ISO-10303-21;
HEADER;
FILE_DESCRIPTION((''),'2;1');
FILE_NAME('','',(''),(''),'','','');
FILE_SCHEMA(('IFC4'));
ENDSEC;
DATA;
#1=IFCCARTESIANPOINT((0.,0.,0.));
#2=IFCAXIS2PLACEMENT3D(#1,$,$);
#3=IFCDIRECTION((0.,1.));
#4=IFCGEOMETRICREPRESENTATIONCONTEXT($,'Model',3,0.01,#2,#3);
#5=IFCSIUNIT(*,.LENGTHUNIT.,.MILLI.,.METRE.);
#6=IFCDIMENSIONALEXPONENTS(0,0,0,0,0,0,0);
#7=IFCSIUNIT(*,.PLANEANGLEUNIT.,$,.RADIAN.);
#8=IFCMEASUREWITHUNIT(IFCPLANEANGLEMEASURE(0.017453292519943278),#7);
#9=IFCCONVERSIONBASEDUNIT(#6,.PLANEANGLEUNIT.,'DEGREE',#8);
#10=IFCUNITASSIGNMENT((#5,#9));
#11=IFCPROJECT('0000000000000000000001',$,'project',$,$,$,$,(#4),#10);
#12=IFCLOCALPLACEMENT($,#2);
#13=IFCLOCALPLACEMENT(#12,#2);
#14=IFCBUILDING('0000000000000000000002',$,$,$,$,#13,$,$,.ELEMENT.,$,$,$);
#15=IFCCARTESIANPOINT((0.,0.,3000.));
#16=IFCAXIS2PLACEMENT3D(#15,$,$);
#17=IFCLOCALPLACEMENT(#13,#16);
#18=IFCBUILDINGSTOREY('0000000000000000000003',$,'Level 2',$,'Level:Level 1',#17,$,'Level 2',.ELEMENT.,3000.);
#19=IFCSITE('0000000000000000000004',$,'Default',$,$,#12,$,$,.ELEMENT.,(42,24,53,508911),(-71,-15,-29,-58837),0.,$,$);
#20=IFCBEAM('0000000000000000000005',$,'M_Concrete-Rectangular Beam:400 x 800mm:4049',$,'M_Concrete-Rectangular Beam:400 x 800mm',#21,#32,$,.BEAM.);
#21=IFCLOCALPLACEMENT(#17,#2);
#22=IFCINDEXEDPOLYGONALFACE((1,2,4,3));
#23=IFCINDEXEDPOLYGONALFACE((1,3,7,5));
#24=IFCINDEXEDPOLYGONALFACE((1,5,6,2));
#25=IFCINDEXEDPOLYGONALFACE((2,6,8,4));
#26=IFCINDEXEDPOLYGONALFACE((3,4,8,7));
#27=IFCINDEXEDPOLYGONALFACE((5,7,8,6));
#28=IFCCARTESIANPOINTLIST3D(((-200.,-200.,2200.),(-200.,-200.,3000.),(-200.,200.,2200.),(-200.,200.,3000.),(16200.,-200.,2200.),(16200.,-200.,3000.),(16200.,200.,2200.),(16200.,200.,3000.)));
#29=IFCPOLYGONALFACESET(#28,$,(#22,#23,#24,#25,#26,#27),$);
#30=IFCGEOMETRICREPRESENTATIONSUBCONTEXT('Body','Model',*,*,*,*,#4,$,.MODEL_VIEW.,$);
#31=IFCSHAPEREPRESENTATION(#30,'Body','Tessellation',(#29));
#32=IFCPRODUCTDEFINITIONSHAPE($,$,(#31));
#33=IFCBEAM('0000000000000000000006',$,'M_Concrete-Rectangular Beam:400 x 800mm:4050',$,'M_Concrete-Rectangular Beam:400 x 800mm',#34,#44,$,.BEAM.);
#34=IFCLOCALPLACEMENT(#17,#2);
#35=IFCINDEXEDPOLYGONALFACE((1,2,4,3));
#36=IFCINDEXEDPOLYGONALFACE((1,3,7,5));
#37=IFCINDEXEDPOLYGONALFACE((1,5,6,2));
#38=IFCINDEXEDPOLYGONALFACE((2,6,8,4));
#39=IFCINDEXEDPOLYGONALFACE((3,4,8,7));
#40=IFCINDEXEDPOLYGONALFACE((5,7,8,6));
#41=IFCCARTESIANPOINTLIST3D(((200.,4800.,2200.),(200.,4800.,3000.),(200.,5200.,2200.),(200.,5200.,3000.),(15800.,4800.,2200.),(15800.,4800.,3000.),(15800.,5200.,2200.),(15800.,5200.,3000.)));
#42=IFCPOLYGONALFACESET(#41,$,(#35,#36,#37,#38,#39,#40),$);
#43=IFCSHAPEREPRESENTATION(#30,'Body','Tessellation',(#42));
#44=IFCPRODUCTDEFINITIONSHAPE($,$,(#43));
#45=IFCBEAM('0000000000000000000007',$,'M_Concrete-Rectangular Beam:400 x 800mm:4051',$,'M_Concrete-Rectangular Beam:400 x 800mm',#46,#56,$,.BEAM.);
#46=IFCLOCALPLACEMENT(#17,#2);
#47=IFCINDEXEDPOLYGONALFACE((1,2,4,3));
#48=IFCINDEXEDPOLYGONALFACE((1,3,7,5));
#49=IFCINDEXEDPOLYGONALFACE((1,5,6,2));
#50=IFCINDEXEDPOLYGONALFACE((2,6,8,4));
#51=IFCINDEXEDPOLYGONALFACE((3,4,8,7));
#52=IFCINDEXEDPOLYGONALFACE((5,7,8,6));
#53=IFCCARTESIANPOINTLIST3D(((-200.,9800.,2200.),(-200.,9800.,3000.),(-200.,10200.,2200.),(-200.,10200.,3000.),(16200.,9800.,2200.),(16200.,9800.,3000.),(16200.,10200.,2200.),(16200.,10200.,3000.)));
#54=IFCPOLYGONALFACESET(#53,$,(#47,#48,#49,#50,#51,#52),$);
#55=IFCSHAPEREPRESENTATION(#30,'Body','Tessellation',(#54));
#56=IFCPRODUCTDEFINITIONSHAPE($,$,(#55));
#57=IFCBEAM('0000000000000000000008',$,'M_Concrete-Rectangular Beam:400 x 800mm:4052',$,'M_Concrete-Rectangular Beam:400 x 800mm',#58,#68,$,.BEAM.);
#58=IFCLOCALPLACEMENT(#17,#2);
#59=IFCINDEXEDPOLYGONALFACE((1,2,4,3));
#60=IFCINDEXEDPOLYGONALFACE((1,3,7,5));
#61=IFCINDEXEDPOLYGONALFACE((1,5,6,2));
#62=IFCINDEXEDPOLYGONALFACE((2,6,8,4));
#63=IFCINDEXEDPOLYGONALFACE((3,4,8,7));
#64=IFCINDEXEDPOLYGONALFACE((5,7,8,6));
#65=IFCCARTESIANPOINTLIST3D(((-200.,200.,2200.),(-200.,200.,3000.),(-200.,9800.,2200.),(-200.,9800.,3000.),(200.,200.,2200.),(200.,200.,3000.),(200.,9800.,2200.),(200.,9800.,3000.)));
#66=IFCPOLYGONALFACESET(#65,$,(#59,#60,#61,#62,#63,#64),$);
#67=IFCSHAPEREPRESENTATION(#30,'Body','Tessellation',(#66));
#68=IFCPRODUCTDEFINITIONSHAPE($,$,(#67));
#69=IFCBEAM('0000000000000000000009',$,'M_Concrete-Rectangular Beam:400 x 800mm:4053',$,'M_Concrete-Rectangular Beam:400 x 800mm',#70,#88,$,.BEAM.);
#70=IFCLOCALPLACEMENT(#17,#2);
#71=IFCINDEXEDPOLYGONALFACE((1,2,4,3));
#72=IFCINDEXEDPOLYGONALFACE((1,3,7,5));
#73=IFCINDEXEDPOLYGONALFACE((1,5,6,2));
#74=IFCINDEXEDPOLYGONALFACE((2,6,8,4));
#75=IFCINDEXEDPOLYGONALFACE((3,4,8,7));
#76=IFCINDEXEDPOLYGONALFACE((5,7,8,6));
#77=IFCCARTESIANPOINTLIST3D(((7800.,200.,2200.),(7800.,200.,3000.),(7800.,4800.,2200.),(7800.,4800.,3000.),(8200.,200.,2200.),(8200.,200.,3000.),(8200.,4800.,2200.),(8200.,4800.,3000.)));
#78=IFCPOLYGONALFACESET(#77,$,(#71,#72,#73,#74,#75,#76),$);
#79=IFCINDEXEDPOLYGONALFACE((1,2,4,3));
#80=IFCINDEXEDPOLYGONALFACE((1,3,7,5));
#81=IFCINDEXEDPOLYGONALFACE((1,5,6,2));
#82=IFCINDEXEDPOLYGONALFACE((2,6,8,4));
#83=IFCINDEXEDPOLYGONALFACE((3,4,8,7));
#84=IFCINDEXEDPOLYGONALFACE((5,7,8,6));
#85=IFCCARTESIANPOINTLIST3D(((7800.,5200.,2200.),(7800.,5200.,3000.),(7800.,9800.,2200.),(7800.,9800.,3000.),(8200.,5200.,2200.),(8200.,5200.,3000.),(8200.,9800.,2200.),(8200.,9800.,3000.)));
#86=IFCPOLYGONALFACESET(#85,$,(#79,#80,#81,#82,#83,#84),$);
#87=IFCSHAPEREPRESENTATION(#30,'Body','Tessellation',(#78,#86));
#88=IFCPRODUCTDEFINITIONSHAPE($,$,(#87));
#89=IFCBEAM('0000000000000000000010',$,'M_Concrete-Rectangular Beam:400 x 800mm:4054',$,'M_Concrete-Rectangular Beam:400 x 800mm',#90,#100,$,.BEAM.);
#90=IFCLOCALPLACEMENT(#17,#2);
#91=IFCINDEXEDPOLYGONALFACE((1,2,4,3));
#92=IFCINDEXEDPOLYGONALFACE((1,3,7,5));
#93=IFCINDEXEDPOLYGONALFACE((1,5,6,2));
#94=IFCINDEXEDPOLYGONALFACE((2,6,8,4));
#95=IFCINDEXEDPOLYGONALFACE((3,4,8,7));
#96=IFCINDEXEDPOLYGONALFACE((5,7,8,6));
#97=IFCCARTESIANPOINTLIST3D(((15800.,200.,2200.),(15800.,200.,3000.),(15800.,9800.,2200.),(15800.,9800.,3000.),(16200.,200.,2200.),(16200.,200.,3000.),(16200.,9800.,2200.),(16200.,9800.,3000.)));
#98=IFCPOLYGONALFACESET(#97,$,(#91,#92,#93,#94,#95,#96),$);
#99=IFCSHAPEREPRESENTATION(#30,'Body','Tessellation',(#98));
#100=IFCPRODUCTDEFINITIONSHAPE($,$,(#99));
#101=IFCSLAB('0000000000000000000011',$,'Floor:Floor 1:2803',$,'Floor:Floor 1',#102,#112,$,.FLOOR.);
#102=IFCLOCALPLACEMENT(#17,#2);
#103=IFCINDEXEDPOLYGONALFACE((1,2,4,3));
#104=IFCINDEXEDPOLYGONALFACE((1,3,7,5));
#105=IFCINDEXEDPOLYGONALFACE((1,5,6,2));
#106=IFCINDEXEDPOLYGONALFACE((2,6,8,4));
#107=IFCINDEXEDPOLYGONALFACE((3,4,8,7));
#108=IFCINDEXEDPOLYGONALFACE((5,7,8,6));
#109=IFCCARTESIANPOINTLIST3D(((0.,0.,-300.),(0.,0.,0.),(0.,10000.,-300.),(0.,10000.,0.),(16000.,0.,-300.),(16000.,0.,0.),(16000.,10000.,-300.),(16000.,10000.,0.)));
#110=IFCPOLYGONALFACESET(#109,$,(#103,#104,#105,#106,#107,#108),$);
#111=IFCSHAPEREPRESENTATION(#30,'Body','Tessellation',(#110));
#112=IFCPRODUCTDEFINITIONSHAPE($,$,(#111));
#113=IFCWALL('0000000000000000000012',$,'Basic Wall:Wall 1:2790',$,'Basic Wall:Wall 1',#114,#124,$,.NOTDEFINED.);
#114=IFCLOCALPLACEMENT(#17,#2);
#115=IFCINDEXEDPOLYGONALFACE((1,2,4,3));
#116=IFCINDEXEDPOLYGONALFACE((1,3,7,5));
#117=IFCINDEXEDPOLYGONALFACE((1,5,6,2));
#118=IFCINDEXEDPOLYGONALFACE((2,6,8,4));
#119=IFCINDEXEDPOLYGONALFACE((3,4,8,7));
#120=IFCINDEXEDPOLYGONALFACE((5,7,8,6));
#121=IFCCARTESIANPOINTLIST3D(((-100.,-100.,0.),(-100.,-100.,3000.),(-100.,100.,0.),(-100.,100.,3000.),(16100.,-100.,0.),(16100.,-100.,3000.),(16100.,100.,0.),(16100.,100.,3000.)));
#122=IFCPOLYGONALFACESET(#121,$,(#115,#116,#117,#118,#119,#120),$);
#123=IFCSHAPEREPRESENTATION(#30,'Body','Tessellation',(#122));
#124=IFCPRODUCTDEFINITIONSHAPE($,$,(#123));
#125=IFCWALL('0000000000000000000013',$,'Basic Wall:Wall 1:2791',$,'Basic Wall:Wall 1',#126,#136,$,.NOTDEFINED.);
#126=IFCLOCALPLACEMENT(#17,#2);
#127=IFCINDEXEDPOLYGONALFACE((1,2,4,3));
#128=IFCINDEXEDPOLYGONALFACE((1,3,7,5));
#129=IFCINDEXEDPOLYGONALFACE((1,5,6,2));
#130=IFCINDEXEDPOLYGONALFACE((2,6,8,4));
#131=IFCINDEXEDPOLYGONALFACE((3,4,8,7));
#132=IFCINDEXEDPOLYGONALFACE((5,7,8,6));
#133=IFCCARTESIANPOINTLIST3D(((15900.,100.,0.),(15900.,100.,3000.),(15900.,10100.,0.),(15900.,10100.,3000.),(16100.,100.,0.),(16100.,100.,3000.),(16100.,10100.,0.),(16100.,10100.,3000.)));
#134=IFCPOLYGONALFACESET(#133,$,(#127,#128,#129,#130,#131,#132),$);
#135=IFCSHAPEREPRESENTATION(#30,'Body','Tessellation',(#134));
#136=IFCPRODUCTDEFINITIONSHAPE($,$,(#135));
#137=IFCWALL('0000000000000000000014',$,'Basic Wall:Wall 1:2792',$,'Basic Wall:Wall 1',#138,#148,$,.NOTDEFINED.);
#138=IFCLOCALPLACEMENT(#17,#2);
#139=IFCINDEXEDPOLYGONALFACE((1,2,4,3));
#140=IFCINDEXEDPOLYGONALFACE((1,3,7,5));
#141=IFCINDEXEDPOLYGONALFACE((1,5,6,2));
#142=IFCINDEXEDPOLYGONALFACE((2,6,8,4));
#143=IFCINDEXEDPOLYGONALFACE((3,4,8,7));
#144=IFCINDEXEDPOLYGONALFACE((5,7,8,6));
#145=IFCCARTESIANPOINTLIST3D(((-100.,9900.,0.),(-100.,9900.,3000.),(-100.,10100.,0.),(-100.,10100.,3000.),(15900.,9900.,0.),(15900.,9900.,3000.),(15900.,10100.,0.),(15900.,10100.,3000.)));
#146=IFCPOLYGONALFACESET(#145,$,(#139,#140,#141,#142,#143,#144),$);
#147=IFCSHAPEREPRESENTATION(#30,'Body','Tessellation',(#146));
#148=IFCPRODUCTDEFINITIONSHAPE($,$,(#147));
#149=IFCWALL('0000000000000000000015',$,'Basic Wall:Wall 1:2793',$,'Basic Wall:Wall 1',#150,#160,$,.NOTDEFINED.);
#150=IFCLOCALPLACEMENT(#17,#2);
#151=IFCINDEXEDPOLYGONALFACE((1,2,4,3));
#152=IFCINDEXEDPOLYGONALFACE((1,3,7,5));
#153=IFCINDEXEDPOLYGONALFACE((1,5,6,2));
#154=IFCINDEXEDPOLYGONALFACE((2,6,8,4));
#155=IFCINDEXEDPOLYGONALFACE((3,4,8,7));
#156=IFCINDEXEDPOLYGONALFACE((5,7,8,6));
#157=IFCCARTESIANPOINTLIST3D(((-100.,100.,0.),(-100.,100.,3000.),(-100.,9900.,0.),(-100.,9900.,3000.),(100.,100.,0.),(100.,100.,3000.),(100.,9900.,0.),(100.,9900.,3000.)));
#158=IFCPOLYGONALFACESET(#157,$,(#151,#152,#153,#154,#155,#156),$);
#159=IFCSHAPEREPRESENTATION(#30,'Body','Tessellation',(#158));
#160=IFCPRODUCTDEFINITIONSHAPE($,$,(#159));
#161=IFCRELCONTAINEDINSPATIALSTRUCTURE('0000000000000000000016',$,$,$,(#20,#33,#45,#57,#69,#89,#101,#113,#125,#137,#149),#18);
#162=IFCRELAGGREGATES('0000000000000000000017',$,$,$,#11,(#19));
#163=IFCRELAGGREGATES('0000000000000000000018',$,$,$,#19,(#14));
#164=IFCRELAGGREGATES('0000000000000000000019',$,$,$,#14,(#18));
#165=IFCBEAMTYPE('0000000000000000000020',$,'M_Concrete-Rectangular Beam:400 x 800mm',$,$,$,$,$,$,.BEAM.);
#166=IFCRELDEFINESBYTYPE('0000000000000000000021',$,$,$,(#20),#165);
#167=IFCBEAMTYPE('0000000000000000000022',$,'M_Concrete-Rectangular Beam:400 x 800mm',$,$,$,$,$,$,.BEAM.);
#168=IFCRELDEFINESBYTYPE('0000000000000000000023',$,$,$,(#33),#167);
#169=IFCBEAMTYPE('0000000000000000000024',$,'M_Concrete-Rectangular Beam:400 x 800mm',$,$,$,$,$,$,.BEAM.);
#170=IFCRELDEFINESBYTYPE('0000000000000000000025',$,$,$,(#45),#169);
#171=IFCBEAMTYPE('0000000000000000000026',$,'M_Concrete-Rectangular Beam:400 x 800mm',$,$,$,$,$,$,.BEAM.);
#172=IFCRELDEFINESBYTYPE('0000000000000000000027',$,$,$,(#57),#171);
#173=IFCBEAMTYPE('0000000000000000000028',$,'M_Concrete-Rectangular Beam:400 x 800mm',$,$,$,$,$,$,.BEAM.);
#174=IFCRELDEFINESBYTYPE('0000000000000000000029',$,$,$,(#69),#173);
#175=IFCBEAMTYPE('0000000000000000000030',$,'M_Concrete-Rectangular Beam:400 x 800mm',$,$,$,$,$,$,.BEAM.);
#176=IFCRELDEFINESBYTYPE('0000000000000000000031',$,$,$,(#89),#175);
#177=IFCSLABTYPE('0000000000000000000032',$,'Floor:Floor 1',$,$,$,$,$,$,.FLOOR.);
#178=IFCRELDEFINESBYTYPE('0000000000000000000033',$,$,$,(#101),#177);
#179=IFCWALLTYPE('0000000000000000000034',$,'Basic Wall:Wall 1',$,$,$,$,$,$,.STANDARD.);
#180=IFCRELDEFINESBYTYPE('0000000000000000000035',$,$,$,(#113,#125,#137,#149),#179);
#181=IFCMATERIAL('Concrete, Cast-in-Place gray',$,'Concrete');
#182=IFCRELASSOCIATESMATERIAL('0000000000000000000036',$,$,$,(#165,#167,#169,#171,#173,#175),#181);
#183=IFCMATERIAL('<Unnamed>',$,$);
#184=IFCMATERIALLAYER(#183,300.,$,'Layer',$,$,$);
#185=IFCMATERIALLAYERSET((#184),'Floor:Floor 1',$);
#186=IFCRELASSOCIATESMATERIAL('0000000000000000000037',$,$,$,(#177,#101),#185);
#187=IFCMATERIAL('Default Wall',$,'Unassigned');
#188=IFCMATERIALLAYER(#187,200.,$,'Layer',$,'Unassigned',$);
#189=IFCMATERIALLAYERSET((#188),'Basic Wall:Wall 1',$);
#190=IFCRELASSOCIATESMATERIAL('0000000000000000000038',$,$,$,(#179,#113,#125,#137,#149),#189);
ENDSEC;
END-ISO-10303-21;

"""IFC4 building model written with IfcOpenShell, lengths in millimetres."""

from ifc_helpers import new_model, entity, si_unit, converted_unit, direction, frame, frame_2d, origin, origin_2d_with_axis, place, context, subcontext, project, spatial, rectangle, extrude, source, transform, mapped, material, layer, layer_set, layer_usage, material_profile, profile_set, type_object, type_shapes, element, save


model = new_model("IFC4")

# Units and contexts
model_context = context("Model", 3, precision=0.01, world=origin(), true_north=direction((0.0, 1.0)))
body_context = subcontext(model_context, "Body", "Model", "MODEL_VIEW")
ifc_project = project(units=[si_unit("LENGTHUNIT", "METRE", prefix="MILLI"), converted_unit("PLANEANGLEUNIT", "DEGREE", entity("IfcPlaneAngleMeasure", 0.017453292519943278), si_unit("PLANEANGLEUNIT", "RADIAN"), dimensions=[0, 0, 0, 0, 0, 0, 0])], contexts=[model_context])

# Site, building, storey
site_placement = place(None, origin())
site = spatial("IfcSite", under=ifc_project, at=site_placement, Name="Default", CompositionType="ELEMENT", RefLatitude=(42, 24, 53, 508911), RefLongitude=(-71, -15, -29, -58837), RefElevation=0.0)
building_placement = place(site_placement, origin())
building = spatial("IfcBuilding", under=site, at=building_placement, CompositionType="ELEMENT")
storey_placement = place(building_placement, frame((0.0, 0.0, 3000.0)))
storey = spatial("IfcBuildingStorey", under=building, at=storey_placement, Name="Level 2", ObjectType="Level:Level 1", LongName="Level 2", CompositionType="ELEMENT", Elevation=3000.0)

# Beams
ifc_material_1 = material(Name="Concrete, Cast-in-Place gray", Category="Concrete")
ifc_material_profile = material_profile(ifc_material_1, rectangle(XDim=800.0, YDim=400.0, at=origin_2d_with_axis()), Name="400 x 800mm")
ifc_profile_set = profile_set([ifc_material_profile], Name="400 x 800mm")
beam_type_1 = type_object("IfcBeamType", Name="M_Concrete-Rectangular Beam:400 x 800mm", PredefinedType="BEAM", material=ifc_profile_set)
shared_shape_1 = source(origin(), body_context, "Body", "SweptSolid", [
    extrude(rectangle(XDim=800.0, YDim=400.0, at=origin_2d_with_axis()), frame((-200.0, 0.0, 5600.0), z_axis=(1.0, 0.0, 0.0), x_axis=(0.0, 0.0, -1.0)), (0.0, 0.0, 1.0), 16400.0),
])
type_shapes(beam_type_1, [shared_shape_1])
beam_1_placement = place(storey_placement, frame((0.0, 0.0, -3000.0)))
element("IfcBeam", 1, at=beam_1_placement, inside=storey, type_object=beam_type_1, Name="M_Concrete-Rectangular Beam:400 x 800mm:4049", ObjectType="M_Concrete-Rectangular Beam:400 x 800mm", PredefinedType="BEAM", context=body_context, shape_type="MappedRepresentation", body=[
    mapped(shared_shape_1, transform((0.0, 0.0, 0.0), scale=1.0)),
])
beam_type_2 = type_object("IfcBeamType", Name="M_Concrete-Rectangular Beam:400 x 800mm", PredefinedType="BEAM", material=ifc_profile_set)
shared_shape_2 = source(origin(), body_context, "Body", "SweptSolid", [
    extrude(rectangle(XDim=800.0, YDim=400.0, at=frame_2d((0.0, 0.0), x_axis=(1.0, 0.0))), frame((200.0, 5000.0, 5600.0), z_axis=(1.0, 0.0, 0.0), x_axis=(0.0, 0.0, -1.0)), (0.0, 0.0, 1.0), 15600.0),
])
type_shapes(beam_type_2, [shared_shape_2])
beam_2_placement = place(storey_placement, frame((0.0, 0.0, -3000.0)))
element("IfcBeam", 2, at=beam_2_placement, inside=storey, type_object=beam_type_2, Name="M_Concrete-Rectangular Beam:400 x 800mm:4050", ObjectType="M_Concrete-Rectangular Beam:400 x 800mm", PredefinedType="BEAM", context=body_context, shape_type="MappedRepresentation", body=[
    mapped(shared_shape_2, transform((0.0, 0.0, 0.0), scale=1.0)),
])
beam_type_3 = type_object("IfcBeamType", Name="M_Concrete-Rectangular Beam:400 x 800mm", PredefinedType="BEAM", material=ifc_profile_set)
shared_shape_3 = source(origin(), body_context, "Body", "SweptSolid", [
    extrude(rectangle(XDim=800.0, YDim=400.0, at=frame_2d((0.0, 0.0), x_axis=(1.0, 0.0))), frame((-200.0, 10000.0, 5600.0), z_axis=(1.0, 0.0, 0.0), x_axis=(0.0, 0.0, -1.0)), (0.0, 0.0, 1.0), 16400.0),
])
type_shapes(beam_type_3, [shared_shape_3])
beam_3_placement = place(storey_placement, frame((0.0, 0.0, -3000.0)))
element("IfcBeam", 3, at=beam_3_placement, inside=storey, type_object=beam_type_3, Name="M_Concrete-Rectangular Beam:400 x 800mm:4051", ObjectType="M_Concrete-Rectangular Beam:400 x 800mm", PredefinedType="BEAM", context=body_context, shape_type="MappedRepresentation", body=[
    mapped(shared_shape_3, transform((0.0, 0.0, 0.0), scale=1.0)),
])
beam_type_4 = type_object("IfcBeamType", Name="M_Concrete-Rectangular Beam:400 x 800mm", PredefinedType="BEAM", material=ifc_profile_set)
shared_shape_4 = source(origin(), body_context, "Body", "SweptSolid", [
    extrude(rectangle(XDim=800.0, YDim=400.0, at=frame_2d((0.0, 0.0), x_axis=(0.0, 1.0))), frame((0.0, 200.0, 5600.0), z_axis=(0.0, 1.0, 0.0), x_axis=(-1.0, 0.0, 0.0)), (0.0, 0.0, 1.0), 9600.0),
])
type_shapes(beam_type_4, [shared_shape_4])
beam_4_placement = place(storey_placement, frame((0.0, 0.0, -3000.0)))
element("IfcBeam", 4, at=beam_4_placement, inside=storey, type_object=beam_type_4, Name="M_Concrete-Rectangular Beam:400 x 800mm:4052", ObjectType="M_Concrete-Rectangular Beam:400 x 800mm", PredefinedType="BEAM", context=body_context, shape_type="MappedRepresentation", body=[
    mapped(shared_shape_4, transform((0.0, 0.0, 0.0), scale=1.0)),
])
beam_type_5 = type_object("IfcBeamType", Name="M_Concrete-Rectangular Beam:400 x 800mm", PredefinedType="BEAM", material=ifc_profile_set)
shared_shape_5 = source(origin(), body_context, "Body", "SweptSolid", [
    extrude(rectangle(XDim=800.0, YDim=400.0, at=frame_2d((0.0, 0.0), x_axis=(0.0, 1.0))), frame((8000.0, 200.0, 5600.0), z_axis=(0.0, 1.0, 0.0), x_axis=(-1.0, 0.0, 0.0)), (0.0, 0.0, 1.0), 4600.0),
    extrude(rectangle(XDim=800.0, YDim=400.0, at=frame_2d((0.0, 0.0), x_axis=(0.0, 1.0))), frame((8000.0, 5200.0, 5600.0), z_axis=(0.0, 1.0, 0.0), x_axis=(-1.0, 0.0, 0.0)), (0.0, 0.0, 1.0), 4600.0),
])
type_shapes(beam_type_5, [shared_shape_5])
beam_5_placement = place(storey_placement, frame((0.0, 0.0, -3000.0)))
element("IfcBeam", 5, at=beam_5_placement, inside=storey, type_object=beam_type_5, Name="M_Concrete-Rectangular Beam:400 x 800mm:4053", ObjectType="M_Concrete-Rectangular Beam:400 x 800mm", PredefinedType="BEAM", context=body_context, shape_type="MappedRepresentation", body=[
    mapped(shared_shape_5, transform((0.0, 0.0, 0.0), scale=1.0)),
])
beam_type_6 = type_object("IfcBeamType", Name="M_Concrete-Rectangular Beam:400 x 800mm", PredefinedType="BEAM", material=ifc_profile_set)
shared_shape_6 = source(origin(), body_context, "Body", "SweptSolid", [
    extrude(rectangle(XDim=800.0, YDim=400.0, at=frame_2d((0.0, 0.0), x_axis=(0.0, 1.0))), frame((16000.0, 200.0, 5600.0), z_axis=(0.0, 1.0, 0.0), x_axis=(-1.0, 0.0, 0.0)), (0.0, 0.0, 1.0), 9600.0),
])
type_shapes(beam_type_6, [shared_shape_6])
beam_6_placement = place(storey_placement, frame((0.0, 0.0, -3000.0)))
element("IfcBeam", 6, at=beam_6_placement, inside=storey, type_object=beam_type_6, Name="M_Concrete-Rectangular Beam:400 x 800mm:4054", ObjectType="M_Concrete-Rectangular Beam:400 x 800mm", PredefinedType="BEAM", context=body_context, shape_type="MappedRepresentation", body=[
    mapped(shared_shape_6, transform((0.0, 0.0, 0.0), scale=1.0)),
])

# Slab
ifc_material_2 = material(Name="<Unnamed>")
ifc_layer_1 = layer(ifc_material_2, 300.0, Name="Layer")
ifc_layer_set_1 = layer_set([ifc_layer_1], Name="Floor:Floor 1")
ifc_layer_usage_1 = layer_usage(ifc_layer_set_1, "AXIS3", "POSITIVE", 0.0)
slab_type = type_object("IfcSlabType", Name="Floor:Floor 1", PredefinedType="FLOOR", material=ifc_layer_set_1)
slab_placement = place(storey_placement, origin())
element("IfcSlab", 7, at=slab_placement, inside=storey, type_object=slab_type, material=ifc_layer_usage_1, Name="Floor:Floor 1:2803", ObjectType="Floor:Floor 1", PredefinedType="FLOOR", context=body_context, shape_type="SweptSolid", body=[
    extrude(rectangle(XDim=10000.0, YDim=16000.0, at=origin_2d_with_axis()), frame((8000.0, 5000.0, 0.0), z_axis=(0.0, 0.0, -1.0), x_axis=(0.0, 1.0, 0.0)), (0.0, 0.0, 1.0), 300.0),
])

# Walls
ifc_material_3 = material(Name="Default Wall", Category="Unassigned")
ifc_layer_2 = layer(ifc_material_3, 200.0, Name="Layer", Category="Unassigned")
ifc_layer_set_2 = layer_set([ifc_layer_2], Name="Basic Wall:Wall 1")
ifc_layer_usage_2 = layer_usage(ifc_layer_set_2, "AXIS2", "NEGATIVE", 100.0)
wall_type = type_object("IfcWallType", Name="Basic Wall:Wall 1", PredefinedType="STANDARD", material=ifc_layer_set_2)
wall_1_placement = place(storey_placement, frame((-100.0, 0.0, 0.0)))
element("IfcWall", 8, at=wall_1_placement, inside=storey, type_object=wall_type, material=ifc_layer_usage_2, Name="Basic Wall:Wall 1:2790", ObjectType="Basic Wall:Wall 1", PredefinedType="NOTDEFINED", context=body_context, shape_type="SweptSolid", body=[
    extrude(rectangle(XDim=16200.0, YDim=200.0, at=frame_2d((8100.0, 0.0), x_axis=(-1.0, 0.0))), origin(), (0.0, 0.0, 1.0), 3000.0),
])
ifc_layer_usage_3 = layer_usage(ifc_layer_set_2, "AXIS2", "NEGATIVE", 100.0)
wall_2_placement = place(storey_placement, frame((16000.0, 100.0, 0.0), z_axis=(0.0, 0.0, 1.0), x_axis=(0.0, 1.0, 0.0)))
element("IfcWall", 9, at=wall_2_placement, inside=storey, type_object=wall_type, material=ifc_layer_usage_3, Name="Basic Wall:Wall 1:2791", ObjectType="Basic Wall:Wall 1", PredefinedType="NOTDEFINED", context=body_context, shape_type="SweptSolid", body=[
    extrude(rectangle(XDim=10000.0, YDim=200.0, at=frame_2d((5000.0, 0.0), x_axis=(-1.0, 0.0))), origin(), (0.0, 0.0, 1.0), 3000.0),
])
ifc_layer_usage_4 = layer_usage(ifc_layer_set_2, "AXIS2", "NEGATIVE", 100.0)
wall_3_placement = place(storey_placement, frame((15900.0, 10000.0, 0.0), z_axis=(0.0, 0.0, 1.0), x_axis=(-1.0, 0.0, 0.0)))
element("IfcWall", 10, at=wall_3_placement, inside=storey, type_object=wall_type, material=ifc_layer_usage_4, Name="Basic Wall:Wall 1:2792", ObjectType="Basic Wall:Wall 1", PredefinedType="NOTDEFINED", context=body_context, shape_type="SweptSolid", body=[
    extrude(rectangle(XDim=16000.0, YDim=200.0, at=frame_2d((8000.0, 0.0), x_axis=(-1.0, 0.0))), origin(), (0.0, 0.0, 1.0), 3000.0),
])
ifc_layer_usage_5 = layer_usage(ifc_layer_set_2, "AXIS2", "NEGATIVE", 100.0)
wall_4_placement = place(storey_placement, frame((0.0, 9900.0, 0.0), z_axis=(0.0, 0.0, 1.0), x_axis=(0.0, -1.0, 0.0)))
element("IfcWall", 11, at=wall_4_placement, inside=storey, type_object=wall_type, material=ifc_layer_usage_5, Name="Basic Wall:Wall 1:2793", ObjectType="Basic Wall:Wall 1", PredefinedType="NOTDEFINED", context=body_context, shape_type="SweptSolid", body=[
    extrude(rectangle(XDim=9800.0, YDim=200.0, at=frame_2d((4900.0, 0.0), x_axis=(-1.0, 0.0))), origin(), (0.0, 0.0, 1.0), 3000.0),
])

save(model, "model.ifc")
